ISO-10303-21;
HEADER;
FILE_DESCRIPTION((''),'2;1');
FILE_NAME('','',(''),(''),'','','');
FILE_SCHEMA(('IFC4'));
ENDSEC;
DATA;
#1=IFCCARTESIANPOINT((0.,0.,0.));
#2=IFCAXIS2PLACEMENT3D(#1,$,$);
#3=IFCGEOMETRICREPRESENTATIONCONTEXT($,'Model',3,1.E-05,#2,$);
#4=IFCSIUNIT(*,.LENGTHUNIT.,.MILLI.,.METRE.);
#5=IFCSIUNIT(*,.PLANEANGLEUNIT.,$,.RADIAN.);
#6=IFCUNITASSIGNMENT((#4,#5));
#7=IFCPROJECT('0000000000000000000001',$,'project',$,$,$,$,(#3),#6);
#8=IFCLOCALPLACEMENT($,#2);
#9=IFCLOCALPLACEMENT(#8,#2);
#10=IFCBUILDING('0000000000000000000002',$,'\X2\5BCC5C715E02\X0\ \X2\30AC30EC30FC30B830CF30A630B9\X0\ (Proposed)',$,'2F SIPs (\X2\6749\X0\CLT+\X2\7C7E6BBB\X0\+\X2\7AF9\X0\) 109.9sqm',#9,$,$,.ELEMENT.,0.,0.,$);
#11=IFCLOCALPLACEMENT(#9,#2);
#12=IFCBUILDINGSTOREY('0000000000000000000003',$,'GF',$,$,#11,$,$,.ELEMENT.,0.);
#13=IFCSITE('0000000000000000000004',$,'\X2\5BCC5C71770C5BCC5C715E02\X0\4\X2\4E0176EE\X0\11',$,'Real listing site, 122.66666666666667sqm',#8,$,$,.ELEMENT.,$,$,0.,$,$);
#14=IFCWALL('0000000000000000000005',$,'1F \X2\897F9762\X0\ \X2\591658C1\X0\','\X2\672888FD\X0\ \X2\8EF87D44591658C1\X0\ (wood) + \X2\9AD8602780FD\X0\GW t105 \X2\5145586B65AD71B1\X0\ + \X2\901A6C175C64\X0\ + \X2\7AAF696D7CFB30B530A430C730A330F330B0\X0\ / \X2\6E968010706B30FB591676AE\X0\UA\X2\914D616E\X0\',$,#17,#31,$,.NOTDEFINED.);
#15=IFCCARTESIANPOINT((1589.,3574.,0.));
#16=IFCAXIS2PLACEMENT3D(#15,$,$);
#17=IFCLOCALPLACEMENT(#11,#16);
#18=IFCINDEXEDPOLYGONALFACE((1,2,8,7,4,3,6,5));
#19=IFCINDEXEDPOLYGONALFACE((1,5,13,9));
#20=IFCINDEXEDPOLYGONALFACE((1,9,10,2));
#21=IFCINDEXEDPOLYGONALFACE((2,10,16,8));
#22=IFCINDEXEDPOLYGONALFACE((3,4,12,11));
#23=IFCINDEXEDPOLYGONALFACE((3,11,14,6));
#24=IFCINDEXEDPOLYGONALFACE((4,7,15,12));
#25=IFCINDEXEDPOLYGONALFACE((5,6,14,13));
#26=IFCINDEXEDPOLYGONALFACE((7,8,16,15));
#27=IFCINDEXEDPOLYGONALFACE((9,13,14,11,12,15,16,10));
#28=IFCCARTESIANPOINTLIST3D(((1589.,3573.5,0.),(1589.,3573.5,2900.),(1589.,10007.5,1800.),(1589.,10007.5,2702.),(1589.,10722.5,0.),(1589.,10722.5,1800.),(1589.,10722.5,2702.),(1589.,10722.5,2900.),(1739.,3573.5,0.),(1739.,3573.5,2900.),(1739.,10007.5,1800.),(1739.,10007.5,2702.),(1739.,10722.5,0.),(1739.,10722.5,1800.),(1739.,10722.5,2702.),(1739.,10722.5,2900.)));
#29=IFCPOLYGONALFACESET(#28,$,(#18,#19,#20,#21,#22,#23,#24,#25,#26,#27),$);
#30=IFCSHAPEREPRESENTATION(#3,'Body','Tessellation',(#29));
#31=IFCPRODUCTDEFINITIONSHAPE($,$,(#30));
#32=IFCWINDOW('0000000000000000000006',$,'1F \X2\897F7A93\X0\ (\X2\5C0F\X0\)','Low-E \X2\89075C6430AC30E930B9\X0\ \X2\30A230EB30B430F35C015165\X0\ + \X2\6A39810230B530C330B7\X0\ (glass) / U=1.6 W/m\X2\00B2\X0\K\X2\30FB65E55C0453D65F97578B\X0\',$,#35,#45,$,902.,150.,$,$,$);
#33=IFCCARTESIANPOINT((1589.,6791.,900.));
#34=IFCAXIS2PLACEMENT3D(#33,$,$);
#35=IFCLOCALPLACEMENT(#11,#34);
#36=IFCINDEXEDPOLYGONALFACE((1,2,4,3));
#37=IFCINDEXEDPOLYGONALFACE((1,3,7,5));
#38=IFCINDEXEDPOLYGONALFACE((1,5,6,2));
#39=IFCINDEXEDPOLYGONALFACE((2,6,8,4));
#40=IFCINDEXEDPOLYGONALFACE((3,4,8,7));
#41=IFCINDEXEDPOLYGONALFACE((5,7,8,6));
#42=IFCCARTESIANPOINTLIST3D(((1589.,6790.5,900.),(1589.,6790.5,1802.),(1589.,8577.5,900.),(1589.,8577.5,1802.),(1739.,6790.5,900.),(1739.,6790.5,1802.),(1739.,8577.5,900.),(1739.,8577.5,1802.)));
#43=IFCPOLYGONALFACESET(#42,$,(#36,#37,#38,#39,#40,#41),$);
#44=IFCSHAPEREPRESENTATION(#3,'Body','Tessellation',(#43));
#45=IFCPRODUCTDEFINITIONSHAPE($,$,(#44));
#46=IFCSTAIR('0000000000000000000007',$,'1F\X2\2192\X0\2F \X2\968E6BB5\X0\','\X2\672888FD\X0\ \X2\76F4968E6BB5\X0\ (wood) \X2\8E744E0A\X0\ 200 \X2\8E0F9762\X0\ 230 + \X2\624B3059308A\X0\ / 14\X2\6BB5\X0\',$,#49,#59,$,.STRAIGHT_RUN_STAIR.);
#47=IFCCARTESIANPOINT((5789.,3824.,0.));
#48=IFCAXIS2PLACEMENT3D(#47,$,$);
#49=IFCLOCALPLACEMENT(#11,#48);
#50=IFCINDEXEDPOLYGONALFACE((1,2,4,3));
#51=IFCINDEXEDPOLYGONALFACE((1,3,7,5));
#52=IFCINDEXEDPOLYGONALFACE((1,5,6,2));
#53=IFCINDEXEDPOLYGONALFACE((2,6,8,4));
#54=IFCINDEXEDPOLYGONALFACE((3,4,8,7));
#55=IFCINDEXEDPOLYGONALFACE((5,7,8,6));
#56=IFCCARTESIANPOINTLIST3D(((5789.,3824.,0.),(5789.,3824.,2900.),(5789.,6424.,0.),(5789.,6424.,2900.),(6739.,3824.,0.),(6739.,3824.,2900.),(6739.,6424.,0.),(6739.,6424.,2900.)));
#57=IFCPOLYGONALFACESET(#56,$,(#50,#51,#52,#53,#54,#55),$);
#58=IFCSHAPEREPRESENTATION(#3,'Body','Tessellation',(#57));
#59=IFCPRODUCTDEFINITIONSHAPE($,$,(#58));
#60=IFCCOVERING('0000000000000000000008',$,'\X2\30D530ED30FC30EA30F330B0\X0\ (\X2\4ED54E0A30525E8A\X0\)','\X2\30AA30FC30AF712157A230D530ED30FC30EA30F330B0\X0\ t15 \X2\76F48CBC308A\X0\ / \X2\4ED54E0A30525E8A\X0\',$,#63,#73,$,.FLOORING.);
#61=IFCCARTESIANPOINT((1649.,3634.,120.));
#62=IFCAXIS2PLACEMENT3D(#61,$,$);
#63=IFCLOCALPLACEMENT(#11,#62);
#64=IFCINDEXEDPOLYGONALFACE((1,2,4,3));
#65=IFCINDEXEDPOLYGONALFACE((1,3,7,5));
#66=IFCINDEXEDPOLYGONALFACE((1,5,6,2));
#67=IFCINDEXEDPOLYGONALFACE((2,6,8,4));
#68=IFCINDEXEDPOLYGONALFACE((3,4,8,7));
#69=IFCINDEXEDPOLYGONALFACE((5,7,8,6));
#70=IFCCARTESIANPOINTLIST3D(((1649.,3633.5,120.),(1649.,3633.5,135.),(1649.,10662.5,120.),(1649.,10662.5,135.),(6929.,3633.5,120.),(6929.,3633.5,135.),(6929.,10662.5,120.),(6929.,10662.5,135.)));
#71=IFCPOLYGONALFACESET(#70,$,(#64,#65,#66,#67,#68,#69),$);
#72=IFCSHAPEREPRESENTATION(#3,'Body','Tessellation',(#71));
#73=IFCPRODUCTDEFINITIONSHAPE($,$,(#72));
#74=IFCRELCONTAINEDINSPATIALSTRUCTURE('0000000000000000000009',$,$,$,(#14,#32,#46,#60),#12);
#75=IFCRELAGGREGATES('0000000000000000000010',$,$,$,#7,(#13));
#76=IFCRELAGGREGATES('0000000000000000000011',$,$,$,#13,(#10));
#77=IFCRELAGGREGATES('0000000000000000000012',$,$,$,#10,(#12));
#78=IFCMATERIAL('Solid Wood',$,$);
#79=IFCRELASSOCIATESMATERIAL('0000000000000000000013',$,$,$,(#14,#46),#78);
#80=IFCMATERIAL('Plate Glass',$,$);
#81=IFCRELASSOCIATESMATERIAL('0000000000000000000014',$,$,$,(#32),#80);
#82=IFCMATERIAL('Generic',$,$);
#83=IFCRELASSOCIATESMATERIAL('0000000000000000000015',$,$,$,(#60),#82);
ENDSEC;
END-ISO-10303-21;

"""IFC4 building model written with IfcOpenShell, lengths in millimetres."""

from ifc_helpers import new_model, si_unit, frame, frame_2d, origin, place, context, project, spatial, rectangle, extrude, material, element, fill, save


model = new_model("IFC4")

# Units and contexts
model_context = context("Model", 3, precision=1e-05, world=origin())
ifc_project = project(units=[si_unit("LENGTHUNIT", "METRE", prefix="MILLI"), si_unit("PLANEANGLEUNIT", "RADIAN")], contexts=[model_context])

# Site, building, storey
site_placement = place(None, origin())
site = spatial("IfcSite", under=ifc_project, at=site_placement, Name="富山県富山市4丁目11", ObjectType="Real listing site, 122.66666666666667sqm", CompositionType="ELEMENT", RefElevation=0.0)
building_placement = place(site_placement, origin())
building = spatial("IfcBuilding", under=site, at=building_placement, Name="富山市 ガレージハウス (Proposed)", ObjectType="2F SIPs (杉CLT+籾殻+竹) 109.9sqm", CompositionType="ELEMENT", ElevationOfRefHeight=0.0, ElevationOfTerrain=0.0)
storey_placement = place(building_placement, origin())
storey = spatial("IfcBuildingStorey", under=building, at=storey_placement, Name="GF", CompositionType="ELEMENT", Elevation=0.0)

# Shared definitions
ifc_material_1 = material(Name="Solid Wood")
ifc_material_2 = material(Name="Generic")

# Shared definitions
ifc_material_3 = material(Name="Plate Glass")

# Wall, opening, window
wall_1_placement = place(storey_placement, frame((1589.0, 3574.0, 0.0)))
wall_1 = element("IfcWall", 1, at=wall_1_placement, inside=storey, material=ifc_material_1, Name="1F 西面 外壁", Description="木製 軸組外壁 (wood) + 高性能GW t105 充填断熱 + 通気層 + 窯業系サイディング / 準耐火・外皮UA配慮", PredefinedType="NOTDEFINED", context=model_context, shape_type="SweptSolid", body=[
    extrude(rectangle(XDim=150.0, YDim=7149.0, at=frame_2d((75.0, 3574.0))), frame((1589.0, 3574.0, 0.0)), (0.0, 0.0, 1.0), 2900.0),
])
opening_1_placement = place(storey_placement, frame((1589.0, 6791.0, 900.0)))
opening_1 = element("IfcOpeningElement", 2, at=opening_1_placement, cuts=wall_1, PredefinedType="NOTDEFINED", context=model_context, shape_type="SweptSolid", body=[
    extrude(rectangle(XDim=150.0, YDim=1787.0, at=frame_2d((75.0, 893.0))), frame((1589.0, 6791.0, 900.0)), (0.0, 0.0, 1.0), 902.0),
])
window_1_placement = place(storey_placement, frame((1589.0, 6791.0, 900.0)))
window_1 = element("IfcWindow", 3, at=window_1_placement, inside=storey, material=ifc_material_3, Name="1F 西窓 (小)", Description="Low-E 複層ガラス アルゴン封入 + 樹脂サッシ (glass) / U=1.6 W/m²K・日射取得型", OverallHeight=902.0, OverallWidth=150.0, context=model_context, shape_type="SweptSolid", body=[
    extrude(rectangle(XDim=150.0, YDim=1787.0, at=frame_2d((75.0, 893.0))), frame((1589.0, 6791.0, 900.0)), (0.0, 0.0, 1.0), 902.0),
])
fill(opening_1, window_1)

# Stair
stair_placement = place(storey_placement, frame((5789.0, 3824.0, 0.0)))
element("IfcStair", 4, at=stair_placement, inside=storey, material=ifc_material_1, Name="1F→2F 階段", Description="木製 直階段 (wood) 蹴上 200 踏面 230 + 手すり / 14段", PredefinedType="STRAIGHT_RUN_STAIR", context=model_context, shape_type="SweptSolid", body=[
    extrude(rectangle(XDim=950.0, YDim=2600.0, at=frame_2d((475.0, 1300.0))), frame((5789.0, 3824.0, 0.0)), (0.0, 0.0, 1.0), 2900.0),
])

# Covering
covering_placement = place(storey_placement, frame((1649.0, 3634.0, 120.0)))
element("IfcCovering", 5, at=covering_placement, inside=storey, material=ifc_material_2, Name="フローリング (仕上げ床)", Description="オーク無垢フローリング t15 直貼り / 仕上げ床", PredefinedType="FLOORING", context=model_context, shape_type="SweptSolid", body=[
    extrude(rectangle(XDim=5280.0, YDim=7029.0, at=frame_2d((2640.0, 3514.0))), frame((1649.0, 3634.0, 120.0)), (0.0, 0.0, 1.0), 15.0),
])

save(model, "model.ifc")
